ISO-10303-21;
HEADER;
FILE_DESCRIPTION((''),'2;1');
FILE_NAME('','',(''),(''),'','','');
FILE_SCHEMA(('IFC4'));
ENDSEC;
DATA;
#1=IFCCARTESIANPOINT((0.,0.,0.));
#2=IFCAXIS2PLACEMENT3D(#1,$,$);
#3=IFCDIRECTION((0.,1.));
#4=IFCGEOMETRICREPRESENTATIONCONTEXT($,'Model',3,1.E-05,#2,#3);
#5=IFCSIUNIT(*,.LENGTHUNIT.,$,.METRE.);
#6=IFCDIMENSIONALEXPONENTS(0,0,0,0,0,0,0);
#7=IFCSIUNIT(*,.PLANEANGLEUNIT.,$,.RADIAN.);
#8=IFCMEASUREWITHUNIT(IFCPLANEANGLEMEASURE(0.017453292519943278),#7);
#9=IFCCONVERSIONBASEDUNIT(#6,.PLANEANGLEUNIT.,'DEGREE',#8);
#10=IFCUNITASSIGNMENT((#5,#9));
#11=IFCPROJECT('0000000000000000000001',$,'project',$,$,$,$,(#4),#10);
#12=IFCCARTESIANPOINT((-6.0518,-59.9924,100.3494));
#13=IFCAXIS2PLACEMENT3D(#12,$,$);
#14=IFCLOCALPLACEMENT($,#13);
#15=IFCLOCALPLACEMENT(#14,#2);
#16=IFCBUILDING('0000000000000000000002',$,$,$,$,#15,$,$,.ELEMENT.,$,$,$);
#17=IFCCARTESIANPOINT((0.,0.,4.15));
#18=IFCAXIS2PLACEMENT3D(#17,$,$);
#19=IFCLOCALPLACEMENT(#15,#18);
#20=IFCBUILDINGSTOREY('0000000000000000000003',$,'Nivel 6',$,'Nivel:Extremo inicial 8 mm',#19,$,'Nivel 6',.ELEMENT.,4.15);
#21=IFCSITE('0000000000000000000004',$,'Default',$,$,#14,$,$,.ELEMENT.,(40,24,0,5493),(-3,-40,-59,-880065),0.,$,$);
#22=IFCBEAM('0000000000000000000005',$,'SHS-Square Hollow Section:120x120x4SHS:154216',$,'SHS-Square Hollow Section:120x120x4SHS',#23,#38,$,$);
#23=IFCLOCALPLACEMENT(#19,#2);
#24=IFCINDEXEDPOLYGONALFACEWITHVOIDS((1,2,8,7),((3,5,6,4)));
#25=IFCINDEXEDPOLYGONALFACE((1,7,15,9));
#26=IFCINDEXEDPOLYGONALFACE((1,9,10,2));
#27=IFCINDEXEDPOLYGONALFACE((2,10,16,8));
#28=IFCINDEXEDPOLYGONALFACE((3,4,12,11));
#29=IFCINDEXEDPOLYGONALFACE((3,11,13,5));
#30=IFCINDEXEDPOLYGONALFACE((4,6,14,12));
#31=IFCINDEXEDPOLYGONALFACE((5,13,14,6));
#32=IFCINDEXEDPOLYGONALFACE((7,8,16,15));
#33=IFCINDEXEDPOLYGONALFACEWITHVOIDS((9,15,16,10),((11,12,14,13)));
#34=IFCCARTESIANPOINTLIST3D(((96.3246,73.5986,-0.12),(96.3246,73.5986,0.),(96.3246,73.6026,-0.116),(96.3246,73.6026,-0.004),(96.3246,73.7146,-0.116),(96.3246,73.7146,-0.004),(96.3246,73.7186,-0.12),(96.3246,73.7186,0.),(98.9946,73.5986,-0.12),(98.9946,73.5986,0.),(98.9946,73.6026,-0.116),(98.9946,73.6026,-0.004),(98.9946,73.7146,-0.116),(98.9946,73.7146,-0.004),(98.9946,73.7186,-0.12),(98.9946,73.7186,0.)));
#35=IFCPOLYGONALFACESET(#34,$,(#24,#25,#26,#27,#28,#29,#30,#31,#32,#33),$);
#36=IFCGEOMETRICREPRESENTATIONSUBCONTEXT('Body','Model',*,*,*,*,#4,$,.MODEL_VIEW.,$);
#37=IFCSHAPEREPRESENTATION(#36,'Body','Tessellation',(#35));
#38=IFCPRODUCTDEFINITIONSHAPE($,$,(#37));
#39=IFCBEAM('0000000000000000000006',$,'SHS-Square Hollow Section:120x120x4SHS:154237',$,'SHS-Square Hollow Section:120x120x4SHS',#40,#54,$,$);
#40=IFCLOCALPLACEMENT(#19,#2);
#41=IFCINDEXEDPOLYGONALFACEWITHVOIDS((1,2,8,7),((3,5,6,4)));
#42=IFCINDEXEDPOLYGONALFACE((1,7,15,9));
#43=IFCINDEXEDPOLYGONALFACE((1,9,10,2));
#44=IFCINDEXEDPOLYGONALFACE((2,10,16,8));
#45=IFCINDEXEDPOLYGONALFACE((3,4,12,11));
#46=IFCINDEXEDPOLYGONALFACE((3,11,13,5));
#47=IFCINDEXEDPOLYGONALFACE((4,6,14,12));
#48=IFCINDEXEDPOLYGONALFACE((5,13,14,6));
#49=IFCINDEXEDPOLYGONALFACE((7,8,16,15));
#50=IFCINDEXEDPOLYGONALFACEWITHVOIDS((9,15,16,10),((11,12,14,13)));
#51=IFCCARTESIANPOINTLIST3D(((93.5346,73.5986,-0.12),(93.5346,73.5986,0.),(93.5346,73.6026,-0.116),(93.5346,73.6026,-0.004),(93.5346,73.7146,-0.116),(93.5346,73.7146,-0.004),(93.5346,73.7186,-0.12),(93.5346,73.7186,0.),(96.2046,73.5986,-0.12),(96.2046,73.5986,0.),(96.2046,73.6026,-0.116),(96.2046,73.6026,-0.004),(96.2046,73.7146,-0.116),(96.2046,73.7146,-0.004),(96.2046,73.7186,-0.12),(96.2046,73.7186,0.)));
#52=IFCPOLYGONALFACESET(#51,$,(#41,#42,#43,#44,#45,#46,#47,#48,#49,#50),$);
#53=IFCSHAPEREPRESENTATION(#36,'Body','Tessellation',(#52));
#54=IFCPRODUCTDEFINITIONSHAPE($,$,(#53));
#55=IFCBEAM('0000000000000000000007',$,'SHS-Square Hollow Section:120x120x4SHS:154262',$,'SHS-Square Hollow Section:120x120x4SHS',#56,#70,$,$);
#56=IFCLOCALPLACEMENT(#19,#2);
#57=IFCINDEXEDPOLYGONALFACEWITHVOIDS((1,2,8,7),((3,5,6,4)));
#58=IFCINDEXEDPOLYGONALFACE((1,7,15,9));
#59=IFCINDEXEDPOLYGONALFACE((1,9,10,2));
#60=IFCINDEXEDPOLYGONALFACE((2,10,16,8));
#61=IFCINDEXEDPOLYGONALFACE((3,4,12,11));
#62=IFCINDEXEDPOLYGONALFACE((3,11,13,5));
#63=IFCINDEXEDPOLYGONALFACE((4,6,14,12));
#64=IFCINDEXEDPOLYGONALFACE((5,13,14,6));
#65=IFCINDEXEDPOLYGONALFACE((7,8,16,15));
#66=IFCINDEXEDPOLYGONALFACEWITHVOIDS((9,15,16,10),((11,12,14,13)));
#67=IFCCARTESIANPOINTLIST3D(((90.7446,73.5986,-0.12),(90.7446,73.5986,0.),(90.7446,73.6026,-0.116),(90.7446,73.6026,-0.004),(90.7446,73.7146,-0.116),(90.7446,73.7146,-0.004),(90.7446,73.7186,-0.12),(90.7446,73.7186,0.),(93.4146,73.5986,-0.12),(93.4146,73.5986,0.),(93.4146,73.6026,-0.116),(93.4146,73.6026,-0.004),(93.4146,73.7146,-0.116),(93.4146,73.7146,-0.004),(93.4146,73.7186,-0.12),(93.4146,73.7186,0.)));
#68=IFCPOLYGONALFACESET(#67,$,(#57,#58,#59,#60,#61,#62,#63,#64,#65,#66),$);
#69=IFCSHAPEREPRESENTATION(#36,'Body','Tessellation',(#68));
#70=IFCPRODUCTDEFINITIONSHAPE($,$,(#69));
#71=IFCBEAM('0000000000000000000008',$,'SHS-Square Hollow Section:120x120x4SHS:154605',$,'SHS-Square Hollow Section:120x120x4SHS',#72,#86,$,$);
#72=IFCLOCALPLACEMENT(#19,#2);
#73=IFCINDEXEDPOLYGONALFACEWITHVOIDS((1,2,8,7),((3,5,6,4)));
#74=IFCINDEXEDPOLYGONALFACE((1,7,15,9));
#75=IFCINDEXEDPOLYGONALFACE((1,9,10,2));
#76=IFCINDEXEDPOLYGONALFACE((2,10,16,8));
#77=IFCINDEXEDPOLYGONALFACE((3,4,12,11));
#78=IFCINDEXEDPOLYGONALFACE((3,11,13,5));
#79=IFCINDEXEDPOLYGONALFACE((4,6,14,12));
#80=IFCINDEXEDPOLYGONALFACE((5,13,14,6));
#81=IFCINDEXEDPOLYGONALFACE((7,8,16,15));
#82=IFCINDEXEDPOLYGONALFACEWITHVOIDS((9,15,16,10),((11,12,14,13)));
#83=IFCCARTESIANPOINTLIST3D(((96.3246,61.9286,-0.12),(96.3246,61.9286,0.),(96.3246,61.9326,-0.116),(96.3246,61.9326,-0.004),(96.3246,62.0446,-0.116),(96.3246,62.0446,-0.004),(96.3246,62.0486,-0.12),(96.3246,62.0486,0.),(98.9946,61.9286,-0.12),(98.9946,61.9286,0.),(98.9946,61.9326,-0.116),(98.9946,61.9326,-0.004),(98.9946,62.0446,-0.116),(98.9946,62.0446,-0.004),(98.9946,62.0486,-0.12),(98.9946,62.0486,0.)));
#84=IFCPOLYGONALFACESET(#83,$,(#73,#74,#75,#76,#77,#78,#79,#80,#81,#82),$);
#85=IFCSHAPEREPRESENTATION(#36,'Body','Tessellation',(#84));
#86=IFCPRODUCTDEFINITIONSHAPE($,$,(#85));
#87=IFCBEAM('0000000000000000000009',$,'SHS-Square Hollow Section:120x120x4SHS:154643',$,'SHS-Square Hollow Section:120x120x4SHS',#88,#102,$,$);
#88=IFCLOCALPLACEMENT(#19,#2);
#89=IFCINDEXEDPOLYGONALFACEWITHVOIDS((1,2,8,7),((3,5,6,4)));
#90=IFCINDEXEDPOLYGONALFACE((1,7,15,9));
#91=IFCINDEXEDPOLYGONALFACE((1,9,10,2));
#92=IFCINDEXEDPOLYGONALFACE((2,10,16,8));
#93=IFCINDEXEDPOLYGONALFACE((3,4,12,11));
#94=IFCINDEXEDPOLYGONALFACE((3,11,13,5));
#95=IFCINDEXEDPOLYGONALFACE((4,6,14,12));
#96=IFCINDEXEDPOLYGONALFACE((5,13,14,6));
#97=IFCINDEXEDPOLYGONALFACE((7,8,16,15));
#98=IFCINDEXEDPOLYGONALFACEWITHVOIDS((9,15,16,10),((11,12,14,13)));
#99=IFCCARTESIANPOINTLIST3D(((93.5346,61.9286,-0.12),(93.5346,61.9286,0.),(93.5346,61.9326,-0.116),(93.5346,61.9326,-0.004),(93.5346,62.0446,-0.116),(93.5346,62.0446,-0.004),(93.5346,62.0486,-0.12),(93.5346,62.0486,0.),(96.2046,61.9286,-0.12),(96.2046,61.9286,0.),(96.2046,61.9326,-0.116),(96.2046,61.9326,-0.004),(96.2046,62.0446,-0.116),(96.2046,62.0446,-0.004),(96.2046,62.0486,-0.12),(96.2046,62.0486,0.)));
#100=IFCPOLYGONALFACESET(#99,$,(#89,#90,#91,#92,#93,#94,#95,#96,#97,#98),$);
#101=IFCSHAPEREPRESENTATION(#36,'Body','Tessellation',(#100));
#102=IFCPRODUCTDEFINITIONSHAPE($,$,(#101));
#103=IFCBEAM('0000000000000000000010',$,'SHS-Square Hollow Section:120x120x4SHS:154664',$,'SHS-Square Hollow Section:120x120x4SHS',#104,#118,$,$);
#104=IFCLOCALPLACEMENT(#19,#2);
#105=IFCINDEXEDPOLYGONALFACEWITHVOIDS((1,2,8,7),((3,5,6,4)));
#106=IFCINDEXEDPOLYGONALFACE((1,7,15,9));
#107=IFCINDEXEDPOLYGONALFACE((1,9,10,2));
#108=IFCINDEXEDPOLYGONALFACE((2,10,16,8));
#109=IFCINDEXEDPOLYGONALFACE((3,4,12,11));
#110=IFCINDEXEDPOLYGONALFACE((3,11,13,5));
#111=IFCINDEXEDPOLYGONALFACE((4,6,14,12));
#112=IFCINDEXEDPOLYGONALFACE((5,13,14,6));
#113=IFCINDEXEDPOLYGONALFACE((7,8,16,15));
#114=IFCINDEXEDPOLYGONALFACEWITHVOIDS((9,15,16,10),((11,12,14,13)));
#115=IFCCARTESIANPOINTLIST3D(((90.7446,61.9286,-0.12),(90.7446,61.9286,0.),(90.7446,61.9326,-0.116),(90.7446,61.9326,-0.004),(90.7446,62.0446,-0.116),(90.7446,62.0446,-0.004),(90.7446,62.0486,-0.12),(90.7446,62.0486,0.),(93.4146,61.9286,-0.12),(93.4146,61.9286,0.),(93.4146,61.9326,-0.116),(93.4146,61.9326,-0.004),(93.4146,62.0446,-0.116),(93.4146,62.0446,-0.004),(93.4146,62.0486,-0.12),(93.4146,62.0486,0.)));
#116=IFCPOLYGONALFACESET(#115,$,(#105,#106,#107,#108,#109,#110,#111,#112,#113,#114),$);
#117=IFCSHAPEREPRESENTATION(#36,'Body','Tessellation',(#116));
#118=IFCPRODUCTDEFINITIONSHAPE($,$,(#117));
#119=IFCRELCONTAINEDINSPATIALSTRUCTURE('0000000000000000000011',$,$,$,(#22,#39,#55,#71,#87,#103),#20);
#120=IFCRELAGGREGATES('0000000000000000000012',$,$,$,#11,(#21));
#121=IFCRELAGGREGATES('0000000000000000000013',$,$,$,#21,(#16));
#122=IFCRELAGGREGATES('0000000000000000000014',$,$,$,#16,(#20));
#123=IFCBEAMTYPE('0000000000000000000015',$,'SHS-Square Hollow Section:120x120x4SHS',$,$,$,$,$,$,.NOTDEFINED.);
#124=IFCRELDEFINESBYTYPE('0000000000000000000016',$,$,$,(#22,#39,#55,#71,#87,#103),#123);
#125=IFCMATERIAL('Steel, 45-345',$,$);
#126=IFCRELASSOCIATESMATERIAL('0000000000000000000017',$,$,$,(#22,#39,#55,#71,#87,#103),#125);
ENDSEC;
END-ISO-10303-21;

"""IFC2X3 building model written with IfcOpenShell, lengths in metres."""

from ifc_helpers import new_model, entity, si_unit, converted_unit, direction, frame, frame_2d, origin, place, context, subcontext, project, spatial, rectangle, extrude, boolean, material, type_object, element, save


model = new_model("IFC2X3")

# Units and contexts
model_context = context("Model", 3, precision=1e-05, world=origin(), true_north=direction((0.0, 1.0)))
body_context = subcontext(model_context, "Body", "Model", "MODEL_VIEW")
ifc_project = project(units=[si_unit("LENGTHUNIT", "METRE"), converted_unit("PLANEANGLEUNIT", "DEGREE", entity("IfcPlaneAngleMeasure", 0.017453292519943278), si_unit("PLANEANGLEUNIT", "RADIAN"), dimensions=[0, 0, 0, 0, 0, 0, 0])], contexts=[model_context])

# Site, building, storey
site_placement = place(None, frame((-6.0518, -59.9924, 100.3494)))
site = spatial("IfcSite", under=ifc_project, at=site_placement, Name="Default", CompositionType="ELEMENT", RefLatitude=(40, 24, 0, 5493), RefLongitude=(-3, -40, -59, -880065), RefElevation=0.0)
building_placement = place(site_placement, origin())
building = spatial("IfcBuilding", under=site, at=building_placement, CompositionType="ELEMENT")
storey_placement = place(building_placement, frame((0.0, 0.0, 4.15)))
storey = spatial("IfcBuildingStorey", under=building, at=storey_placement, Name="Nivel 6", ObjectType="Nivel:Extremo inicial 8 mm", LongName="Nivel 6", CompositionType="ELEMENT", Elevation=4.15)

# Beams
ifc_material_1 = material(Name="Steel, 45-345")
beam_type = type_object("IfcBeamType", Name="SHS-Square Hollow Section:120x120x4SHS", PredefinedType="NOTDEFINED")
for number, where, z_axis, x_axis, name in (
    (1, (99.0546, 73.6586, 0.0), (0.0, 0.0, 1.0), (-1.0, 0.0, 0.0), "SHS-Square Hollow Section:120x120x4SHS:154216"),
    (2, (96.2646, 73.6586, 0.0), (0.0, 0.0, 1.0), (-1.0, 0.0, 0.0), "SHS-Square Hollow Section:120x120x4SHS:154237"),
    (3, (93.4746, 73.6586, 0.0), (0.0, 0.0, 1.0), (-1.0, 0.0, 0.0), "SHS-Square Hollow Section:120x120x4SHS:154262"),
):
    element("IfcBeam", number, at=place(storey_placement, frame(where, z_axis=z_axis, x_axis=x_axis)), inside=storey, type_object=beam_type, material=ifc_material_1, Name=name, ObjectType="SHS-Square Hollow Section:120x120x4SHS", context=body_context, shape_type="SweptSolid", body=[
        boolean("DIFFERENCE", extrude(rectangle(XDim=0.12, YDim=0.12, at=frame_2d((0.0, 0.0), x_axis=(1.0, 0.0))), frame((0.06, 0.0, -0.06), z_axis=(1.0, 0.0, 0.0), x_axis=(0.0, 0.0, -1.0)), (0.0, 0.0, 1.0), 2.67), extrude(rectangle(XDim=0.112, YDim=0.112, at=frame_2d((0.0, 0.0), x_axis=(0.0, 1.0))), frame((2.73, 0.0, -0.06), z_axis=(-1.0, 0.0, 0.0), x_axis=(0.0, 1.0, 0.0)), (0.0, 0.0, 1.0), 2.67)),
    ])
beam_1_placement = place(storey_placement, frame((99.0546, 61.9886, 0.0), z_axis=(0.0, 0.0, 1.0), x_axis=(-1.0, 0.0, 0.0)))
element("IfcBeam", 4, at=beam_1_placement, inside=storey, type_object=beam_type, material=ifc_material_1, Name="SHS-Square Hollow Section:120x120x4SHS:154605", ObjectType="SHS-Square Hollow Section:120x120x4SHS", context=body_context, shape_type="SweptSolid", body=[
    boolean("DIFFERENCE", extrude(rectangle(XDim=0.12, YDim=0.12, at=frame_2d((0.0, 0.0), x_axis=(1.0, 0.0))), frame((0.06, 0.0, -0.06), z_axis=(1.0, 0.0, 0.0), x_axis=(0.0, 0.0, -1.0)), (0.0, 0.0, 1.0), 2.67), extrude(rectangle(XDim=0.112, YDim=0.112, at=frame_2d((0.0, 0.0), x_axis=(0.0, 1.0))), frame((2.73, 0.0, -0.06), z_axis=(-1.0, 0.0, 0.0), x_axis=(0.0, 1.0, 0.0)), (0.0, 0.0, 1.0), 2.67)),
])
beam_2_placement = place(storey_placement, frame((96.2646, 61.9886, 0.0), z_axis=(0.0, 0.0, 1.0), x_axis=(-1.0, 0.0, 0.0)))
element("IfcBeam", 5, at=beam_2_placement, inside=storey, type_object=beam_type, material=ifc_material_1, Name="SHS-Square Hollow Section:120x120x4SHS:154643", ObjectType="SHS-Square Hollow Section:120x120x4SHS", context=body_context, shape_type="SweptSolid", body=[
    boolean("DIFFERENCE", extrude(rectangle(XDim=0.12, YDim=0.12, at=frame_2d((0.0, 0.0), x_axis=(1.0, 0.0))), frame((0.06, 0.0, -0.06), z_axis=(1.0, 0.0, 0.0), x_axis=(0.0, 0.0, -1.0)), (0.0, 0.0, 1.0), 2.67), extrude(rectangle(XDim=0.112, YDim=0.112, at=frame_2d((0.0, 0.0), x_axis=(0.0, 1.0))), frame((2.73, 0.0, -0.06), z_axis=(-1.0, 0.0, 0.0), x_axis=(0.0, 1.0, 0.0)), (0.0, 0.0, 1.0), 2.67)),
])
beam_3_placement = place(storey_placement, frame((93.4746, 61.9886, 0.0), z_axis=(0.0, 0.0, 1.0), x_axis=(-1.0, 0.0, 0.0)))
element("IfcBeam", 6, at=beam_3_placement, inside=storey, type_object=beam_type, material=ifc_material_1, Name="SHS-Square Hollow Section:120x120x4SHS:154664", ObjectType="SHS-Square Hollow Section:120x120x4SHS", context=body_context, shape_type="SweptSolid", body=[
    boolean("DIFFERENCE", extrude(rectangle(XDim=0.12, YDim=0.12, at=frame_2d((0.0, 0.0), x_axis=(1.0, 0.0))), frame((0.06, 0.0, -0.06), z_axis=(1.0, 0.0, 0.0), x_axis=(0.0, 0.0, -1.0)), (0.0, 0.0, 1.0), 2.67), extrude(rectangle(XDim=0.112, YDim=0.112, at=frame_2d((0.0, 0.0), x_axis=(0.0, 1.0))), frame((2.73, 0.0, -0.06), z_axis=(-1.0, 0.0, 0.0), x_axis=(0.0, 1.0, 0.0)), (0.0, 0.0, 1.0), 2.67)),
])

save(model, "model.ifc")
